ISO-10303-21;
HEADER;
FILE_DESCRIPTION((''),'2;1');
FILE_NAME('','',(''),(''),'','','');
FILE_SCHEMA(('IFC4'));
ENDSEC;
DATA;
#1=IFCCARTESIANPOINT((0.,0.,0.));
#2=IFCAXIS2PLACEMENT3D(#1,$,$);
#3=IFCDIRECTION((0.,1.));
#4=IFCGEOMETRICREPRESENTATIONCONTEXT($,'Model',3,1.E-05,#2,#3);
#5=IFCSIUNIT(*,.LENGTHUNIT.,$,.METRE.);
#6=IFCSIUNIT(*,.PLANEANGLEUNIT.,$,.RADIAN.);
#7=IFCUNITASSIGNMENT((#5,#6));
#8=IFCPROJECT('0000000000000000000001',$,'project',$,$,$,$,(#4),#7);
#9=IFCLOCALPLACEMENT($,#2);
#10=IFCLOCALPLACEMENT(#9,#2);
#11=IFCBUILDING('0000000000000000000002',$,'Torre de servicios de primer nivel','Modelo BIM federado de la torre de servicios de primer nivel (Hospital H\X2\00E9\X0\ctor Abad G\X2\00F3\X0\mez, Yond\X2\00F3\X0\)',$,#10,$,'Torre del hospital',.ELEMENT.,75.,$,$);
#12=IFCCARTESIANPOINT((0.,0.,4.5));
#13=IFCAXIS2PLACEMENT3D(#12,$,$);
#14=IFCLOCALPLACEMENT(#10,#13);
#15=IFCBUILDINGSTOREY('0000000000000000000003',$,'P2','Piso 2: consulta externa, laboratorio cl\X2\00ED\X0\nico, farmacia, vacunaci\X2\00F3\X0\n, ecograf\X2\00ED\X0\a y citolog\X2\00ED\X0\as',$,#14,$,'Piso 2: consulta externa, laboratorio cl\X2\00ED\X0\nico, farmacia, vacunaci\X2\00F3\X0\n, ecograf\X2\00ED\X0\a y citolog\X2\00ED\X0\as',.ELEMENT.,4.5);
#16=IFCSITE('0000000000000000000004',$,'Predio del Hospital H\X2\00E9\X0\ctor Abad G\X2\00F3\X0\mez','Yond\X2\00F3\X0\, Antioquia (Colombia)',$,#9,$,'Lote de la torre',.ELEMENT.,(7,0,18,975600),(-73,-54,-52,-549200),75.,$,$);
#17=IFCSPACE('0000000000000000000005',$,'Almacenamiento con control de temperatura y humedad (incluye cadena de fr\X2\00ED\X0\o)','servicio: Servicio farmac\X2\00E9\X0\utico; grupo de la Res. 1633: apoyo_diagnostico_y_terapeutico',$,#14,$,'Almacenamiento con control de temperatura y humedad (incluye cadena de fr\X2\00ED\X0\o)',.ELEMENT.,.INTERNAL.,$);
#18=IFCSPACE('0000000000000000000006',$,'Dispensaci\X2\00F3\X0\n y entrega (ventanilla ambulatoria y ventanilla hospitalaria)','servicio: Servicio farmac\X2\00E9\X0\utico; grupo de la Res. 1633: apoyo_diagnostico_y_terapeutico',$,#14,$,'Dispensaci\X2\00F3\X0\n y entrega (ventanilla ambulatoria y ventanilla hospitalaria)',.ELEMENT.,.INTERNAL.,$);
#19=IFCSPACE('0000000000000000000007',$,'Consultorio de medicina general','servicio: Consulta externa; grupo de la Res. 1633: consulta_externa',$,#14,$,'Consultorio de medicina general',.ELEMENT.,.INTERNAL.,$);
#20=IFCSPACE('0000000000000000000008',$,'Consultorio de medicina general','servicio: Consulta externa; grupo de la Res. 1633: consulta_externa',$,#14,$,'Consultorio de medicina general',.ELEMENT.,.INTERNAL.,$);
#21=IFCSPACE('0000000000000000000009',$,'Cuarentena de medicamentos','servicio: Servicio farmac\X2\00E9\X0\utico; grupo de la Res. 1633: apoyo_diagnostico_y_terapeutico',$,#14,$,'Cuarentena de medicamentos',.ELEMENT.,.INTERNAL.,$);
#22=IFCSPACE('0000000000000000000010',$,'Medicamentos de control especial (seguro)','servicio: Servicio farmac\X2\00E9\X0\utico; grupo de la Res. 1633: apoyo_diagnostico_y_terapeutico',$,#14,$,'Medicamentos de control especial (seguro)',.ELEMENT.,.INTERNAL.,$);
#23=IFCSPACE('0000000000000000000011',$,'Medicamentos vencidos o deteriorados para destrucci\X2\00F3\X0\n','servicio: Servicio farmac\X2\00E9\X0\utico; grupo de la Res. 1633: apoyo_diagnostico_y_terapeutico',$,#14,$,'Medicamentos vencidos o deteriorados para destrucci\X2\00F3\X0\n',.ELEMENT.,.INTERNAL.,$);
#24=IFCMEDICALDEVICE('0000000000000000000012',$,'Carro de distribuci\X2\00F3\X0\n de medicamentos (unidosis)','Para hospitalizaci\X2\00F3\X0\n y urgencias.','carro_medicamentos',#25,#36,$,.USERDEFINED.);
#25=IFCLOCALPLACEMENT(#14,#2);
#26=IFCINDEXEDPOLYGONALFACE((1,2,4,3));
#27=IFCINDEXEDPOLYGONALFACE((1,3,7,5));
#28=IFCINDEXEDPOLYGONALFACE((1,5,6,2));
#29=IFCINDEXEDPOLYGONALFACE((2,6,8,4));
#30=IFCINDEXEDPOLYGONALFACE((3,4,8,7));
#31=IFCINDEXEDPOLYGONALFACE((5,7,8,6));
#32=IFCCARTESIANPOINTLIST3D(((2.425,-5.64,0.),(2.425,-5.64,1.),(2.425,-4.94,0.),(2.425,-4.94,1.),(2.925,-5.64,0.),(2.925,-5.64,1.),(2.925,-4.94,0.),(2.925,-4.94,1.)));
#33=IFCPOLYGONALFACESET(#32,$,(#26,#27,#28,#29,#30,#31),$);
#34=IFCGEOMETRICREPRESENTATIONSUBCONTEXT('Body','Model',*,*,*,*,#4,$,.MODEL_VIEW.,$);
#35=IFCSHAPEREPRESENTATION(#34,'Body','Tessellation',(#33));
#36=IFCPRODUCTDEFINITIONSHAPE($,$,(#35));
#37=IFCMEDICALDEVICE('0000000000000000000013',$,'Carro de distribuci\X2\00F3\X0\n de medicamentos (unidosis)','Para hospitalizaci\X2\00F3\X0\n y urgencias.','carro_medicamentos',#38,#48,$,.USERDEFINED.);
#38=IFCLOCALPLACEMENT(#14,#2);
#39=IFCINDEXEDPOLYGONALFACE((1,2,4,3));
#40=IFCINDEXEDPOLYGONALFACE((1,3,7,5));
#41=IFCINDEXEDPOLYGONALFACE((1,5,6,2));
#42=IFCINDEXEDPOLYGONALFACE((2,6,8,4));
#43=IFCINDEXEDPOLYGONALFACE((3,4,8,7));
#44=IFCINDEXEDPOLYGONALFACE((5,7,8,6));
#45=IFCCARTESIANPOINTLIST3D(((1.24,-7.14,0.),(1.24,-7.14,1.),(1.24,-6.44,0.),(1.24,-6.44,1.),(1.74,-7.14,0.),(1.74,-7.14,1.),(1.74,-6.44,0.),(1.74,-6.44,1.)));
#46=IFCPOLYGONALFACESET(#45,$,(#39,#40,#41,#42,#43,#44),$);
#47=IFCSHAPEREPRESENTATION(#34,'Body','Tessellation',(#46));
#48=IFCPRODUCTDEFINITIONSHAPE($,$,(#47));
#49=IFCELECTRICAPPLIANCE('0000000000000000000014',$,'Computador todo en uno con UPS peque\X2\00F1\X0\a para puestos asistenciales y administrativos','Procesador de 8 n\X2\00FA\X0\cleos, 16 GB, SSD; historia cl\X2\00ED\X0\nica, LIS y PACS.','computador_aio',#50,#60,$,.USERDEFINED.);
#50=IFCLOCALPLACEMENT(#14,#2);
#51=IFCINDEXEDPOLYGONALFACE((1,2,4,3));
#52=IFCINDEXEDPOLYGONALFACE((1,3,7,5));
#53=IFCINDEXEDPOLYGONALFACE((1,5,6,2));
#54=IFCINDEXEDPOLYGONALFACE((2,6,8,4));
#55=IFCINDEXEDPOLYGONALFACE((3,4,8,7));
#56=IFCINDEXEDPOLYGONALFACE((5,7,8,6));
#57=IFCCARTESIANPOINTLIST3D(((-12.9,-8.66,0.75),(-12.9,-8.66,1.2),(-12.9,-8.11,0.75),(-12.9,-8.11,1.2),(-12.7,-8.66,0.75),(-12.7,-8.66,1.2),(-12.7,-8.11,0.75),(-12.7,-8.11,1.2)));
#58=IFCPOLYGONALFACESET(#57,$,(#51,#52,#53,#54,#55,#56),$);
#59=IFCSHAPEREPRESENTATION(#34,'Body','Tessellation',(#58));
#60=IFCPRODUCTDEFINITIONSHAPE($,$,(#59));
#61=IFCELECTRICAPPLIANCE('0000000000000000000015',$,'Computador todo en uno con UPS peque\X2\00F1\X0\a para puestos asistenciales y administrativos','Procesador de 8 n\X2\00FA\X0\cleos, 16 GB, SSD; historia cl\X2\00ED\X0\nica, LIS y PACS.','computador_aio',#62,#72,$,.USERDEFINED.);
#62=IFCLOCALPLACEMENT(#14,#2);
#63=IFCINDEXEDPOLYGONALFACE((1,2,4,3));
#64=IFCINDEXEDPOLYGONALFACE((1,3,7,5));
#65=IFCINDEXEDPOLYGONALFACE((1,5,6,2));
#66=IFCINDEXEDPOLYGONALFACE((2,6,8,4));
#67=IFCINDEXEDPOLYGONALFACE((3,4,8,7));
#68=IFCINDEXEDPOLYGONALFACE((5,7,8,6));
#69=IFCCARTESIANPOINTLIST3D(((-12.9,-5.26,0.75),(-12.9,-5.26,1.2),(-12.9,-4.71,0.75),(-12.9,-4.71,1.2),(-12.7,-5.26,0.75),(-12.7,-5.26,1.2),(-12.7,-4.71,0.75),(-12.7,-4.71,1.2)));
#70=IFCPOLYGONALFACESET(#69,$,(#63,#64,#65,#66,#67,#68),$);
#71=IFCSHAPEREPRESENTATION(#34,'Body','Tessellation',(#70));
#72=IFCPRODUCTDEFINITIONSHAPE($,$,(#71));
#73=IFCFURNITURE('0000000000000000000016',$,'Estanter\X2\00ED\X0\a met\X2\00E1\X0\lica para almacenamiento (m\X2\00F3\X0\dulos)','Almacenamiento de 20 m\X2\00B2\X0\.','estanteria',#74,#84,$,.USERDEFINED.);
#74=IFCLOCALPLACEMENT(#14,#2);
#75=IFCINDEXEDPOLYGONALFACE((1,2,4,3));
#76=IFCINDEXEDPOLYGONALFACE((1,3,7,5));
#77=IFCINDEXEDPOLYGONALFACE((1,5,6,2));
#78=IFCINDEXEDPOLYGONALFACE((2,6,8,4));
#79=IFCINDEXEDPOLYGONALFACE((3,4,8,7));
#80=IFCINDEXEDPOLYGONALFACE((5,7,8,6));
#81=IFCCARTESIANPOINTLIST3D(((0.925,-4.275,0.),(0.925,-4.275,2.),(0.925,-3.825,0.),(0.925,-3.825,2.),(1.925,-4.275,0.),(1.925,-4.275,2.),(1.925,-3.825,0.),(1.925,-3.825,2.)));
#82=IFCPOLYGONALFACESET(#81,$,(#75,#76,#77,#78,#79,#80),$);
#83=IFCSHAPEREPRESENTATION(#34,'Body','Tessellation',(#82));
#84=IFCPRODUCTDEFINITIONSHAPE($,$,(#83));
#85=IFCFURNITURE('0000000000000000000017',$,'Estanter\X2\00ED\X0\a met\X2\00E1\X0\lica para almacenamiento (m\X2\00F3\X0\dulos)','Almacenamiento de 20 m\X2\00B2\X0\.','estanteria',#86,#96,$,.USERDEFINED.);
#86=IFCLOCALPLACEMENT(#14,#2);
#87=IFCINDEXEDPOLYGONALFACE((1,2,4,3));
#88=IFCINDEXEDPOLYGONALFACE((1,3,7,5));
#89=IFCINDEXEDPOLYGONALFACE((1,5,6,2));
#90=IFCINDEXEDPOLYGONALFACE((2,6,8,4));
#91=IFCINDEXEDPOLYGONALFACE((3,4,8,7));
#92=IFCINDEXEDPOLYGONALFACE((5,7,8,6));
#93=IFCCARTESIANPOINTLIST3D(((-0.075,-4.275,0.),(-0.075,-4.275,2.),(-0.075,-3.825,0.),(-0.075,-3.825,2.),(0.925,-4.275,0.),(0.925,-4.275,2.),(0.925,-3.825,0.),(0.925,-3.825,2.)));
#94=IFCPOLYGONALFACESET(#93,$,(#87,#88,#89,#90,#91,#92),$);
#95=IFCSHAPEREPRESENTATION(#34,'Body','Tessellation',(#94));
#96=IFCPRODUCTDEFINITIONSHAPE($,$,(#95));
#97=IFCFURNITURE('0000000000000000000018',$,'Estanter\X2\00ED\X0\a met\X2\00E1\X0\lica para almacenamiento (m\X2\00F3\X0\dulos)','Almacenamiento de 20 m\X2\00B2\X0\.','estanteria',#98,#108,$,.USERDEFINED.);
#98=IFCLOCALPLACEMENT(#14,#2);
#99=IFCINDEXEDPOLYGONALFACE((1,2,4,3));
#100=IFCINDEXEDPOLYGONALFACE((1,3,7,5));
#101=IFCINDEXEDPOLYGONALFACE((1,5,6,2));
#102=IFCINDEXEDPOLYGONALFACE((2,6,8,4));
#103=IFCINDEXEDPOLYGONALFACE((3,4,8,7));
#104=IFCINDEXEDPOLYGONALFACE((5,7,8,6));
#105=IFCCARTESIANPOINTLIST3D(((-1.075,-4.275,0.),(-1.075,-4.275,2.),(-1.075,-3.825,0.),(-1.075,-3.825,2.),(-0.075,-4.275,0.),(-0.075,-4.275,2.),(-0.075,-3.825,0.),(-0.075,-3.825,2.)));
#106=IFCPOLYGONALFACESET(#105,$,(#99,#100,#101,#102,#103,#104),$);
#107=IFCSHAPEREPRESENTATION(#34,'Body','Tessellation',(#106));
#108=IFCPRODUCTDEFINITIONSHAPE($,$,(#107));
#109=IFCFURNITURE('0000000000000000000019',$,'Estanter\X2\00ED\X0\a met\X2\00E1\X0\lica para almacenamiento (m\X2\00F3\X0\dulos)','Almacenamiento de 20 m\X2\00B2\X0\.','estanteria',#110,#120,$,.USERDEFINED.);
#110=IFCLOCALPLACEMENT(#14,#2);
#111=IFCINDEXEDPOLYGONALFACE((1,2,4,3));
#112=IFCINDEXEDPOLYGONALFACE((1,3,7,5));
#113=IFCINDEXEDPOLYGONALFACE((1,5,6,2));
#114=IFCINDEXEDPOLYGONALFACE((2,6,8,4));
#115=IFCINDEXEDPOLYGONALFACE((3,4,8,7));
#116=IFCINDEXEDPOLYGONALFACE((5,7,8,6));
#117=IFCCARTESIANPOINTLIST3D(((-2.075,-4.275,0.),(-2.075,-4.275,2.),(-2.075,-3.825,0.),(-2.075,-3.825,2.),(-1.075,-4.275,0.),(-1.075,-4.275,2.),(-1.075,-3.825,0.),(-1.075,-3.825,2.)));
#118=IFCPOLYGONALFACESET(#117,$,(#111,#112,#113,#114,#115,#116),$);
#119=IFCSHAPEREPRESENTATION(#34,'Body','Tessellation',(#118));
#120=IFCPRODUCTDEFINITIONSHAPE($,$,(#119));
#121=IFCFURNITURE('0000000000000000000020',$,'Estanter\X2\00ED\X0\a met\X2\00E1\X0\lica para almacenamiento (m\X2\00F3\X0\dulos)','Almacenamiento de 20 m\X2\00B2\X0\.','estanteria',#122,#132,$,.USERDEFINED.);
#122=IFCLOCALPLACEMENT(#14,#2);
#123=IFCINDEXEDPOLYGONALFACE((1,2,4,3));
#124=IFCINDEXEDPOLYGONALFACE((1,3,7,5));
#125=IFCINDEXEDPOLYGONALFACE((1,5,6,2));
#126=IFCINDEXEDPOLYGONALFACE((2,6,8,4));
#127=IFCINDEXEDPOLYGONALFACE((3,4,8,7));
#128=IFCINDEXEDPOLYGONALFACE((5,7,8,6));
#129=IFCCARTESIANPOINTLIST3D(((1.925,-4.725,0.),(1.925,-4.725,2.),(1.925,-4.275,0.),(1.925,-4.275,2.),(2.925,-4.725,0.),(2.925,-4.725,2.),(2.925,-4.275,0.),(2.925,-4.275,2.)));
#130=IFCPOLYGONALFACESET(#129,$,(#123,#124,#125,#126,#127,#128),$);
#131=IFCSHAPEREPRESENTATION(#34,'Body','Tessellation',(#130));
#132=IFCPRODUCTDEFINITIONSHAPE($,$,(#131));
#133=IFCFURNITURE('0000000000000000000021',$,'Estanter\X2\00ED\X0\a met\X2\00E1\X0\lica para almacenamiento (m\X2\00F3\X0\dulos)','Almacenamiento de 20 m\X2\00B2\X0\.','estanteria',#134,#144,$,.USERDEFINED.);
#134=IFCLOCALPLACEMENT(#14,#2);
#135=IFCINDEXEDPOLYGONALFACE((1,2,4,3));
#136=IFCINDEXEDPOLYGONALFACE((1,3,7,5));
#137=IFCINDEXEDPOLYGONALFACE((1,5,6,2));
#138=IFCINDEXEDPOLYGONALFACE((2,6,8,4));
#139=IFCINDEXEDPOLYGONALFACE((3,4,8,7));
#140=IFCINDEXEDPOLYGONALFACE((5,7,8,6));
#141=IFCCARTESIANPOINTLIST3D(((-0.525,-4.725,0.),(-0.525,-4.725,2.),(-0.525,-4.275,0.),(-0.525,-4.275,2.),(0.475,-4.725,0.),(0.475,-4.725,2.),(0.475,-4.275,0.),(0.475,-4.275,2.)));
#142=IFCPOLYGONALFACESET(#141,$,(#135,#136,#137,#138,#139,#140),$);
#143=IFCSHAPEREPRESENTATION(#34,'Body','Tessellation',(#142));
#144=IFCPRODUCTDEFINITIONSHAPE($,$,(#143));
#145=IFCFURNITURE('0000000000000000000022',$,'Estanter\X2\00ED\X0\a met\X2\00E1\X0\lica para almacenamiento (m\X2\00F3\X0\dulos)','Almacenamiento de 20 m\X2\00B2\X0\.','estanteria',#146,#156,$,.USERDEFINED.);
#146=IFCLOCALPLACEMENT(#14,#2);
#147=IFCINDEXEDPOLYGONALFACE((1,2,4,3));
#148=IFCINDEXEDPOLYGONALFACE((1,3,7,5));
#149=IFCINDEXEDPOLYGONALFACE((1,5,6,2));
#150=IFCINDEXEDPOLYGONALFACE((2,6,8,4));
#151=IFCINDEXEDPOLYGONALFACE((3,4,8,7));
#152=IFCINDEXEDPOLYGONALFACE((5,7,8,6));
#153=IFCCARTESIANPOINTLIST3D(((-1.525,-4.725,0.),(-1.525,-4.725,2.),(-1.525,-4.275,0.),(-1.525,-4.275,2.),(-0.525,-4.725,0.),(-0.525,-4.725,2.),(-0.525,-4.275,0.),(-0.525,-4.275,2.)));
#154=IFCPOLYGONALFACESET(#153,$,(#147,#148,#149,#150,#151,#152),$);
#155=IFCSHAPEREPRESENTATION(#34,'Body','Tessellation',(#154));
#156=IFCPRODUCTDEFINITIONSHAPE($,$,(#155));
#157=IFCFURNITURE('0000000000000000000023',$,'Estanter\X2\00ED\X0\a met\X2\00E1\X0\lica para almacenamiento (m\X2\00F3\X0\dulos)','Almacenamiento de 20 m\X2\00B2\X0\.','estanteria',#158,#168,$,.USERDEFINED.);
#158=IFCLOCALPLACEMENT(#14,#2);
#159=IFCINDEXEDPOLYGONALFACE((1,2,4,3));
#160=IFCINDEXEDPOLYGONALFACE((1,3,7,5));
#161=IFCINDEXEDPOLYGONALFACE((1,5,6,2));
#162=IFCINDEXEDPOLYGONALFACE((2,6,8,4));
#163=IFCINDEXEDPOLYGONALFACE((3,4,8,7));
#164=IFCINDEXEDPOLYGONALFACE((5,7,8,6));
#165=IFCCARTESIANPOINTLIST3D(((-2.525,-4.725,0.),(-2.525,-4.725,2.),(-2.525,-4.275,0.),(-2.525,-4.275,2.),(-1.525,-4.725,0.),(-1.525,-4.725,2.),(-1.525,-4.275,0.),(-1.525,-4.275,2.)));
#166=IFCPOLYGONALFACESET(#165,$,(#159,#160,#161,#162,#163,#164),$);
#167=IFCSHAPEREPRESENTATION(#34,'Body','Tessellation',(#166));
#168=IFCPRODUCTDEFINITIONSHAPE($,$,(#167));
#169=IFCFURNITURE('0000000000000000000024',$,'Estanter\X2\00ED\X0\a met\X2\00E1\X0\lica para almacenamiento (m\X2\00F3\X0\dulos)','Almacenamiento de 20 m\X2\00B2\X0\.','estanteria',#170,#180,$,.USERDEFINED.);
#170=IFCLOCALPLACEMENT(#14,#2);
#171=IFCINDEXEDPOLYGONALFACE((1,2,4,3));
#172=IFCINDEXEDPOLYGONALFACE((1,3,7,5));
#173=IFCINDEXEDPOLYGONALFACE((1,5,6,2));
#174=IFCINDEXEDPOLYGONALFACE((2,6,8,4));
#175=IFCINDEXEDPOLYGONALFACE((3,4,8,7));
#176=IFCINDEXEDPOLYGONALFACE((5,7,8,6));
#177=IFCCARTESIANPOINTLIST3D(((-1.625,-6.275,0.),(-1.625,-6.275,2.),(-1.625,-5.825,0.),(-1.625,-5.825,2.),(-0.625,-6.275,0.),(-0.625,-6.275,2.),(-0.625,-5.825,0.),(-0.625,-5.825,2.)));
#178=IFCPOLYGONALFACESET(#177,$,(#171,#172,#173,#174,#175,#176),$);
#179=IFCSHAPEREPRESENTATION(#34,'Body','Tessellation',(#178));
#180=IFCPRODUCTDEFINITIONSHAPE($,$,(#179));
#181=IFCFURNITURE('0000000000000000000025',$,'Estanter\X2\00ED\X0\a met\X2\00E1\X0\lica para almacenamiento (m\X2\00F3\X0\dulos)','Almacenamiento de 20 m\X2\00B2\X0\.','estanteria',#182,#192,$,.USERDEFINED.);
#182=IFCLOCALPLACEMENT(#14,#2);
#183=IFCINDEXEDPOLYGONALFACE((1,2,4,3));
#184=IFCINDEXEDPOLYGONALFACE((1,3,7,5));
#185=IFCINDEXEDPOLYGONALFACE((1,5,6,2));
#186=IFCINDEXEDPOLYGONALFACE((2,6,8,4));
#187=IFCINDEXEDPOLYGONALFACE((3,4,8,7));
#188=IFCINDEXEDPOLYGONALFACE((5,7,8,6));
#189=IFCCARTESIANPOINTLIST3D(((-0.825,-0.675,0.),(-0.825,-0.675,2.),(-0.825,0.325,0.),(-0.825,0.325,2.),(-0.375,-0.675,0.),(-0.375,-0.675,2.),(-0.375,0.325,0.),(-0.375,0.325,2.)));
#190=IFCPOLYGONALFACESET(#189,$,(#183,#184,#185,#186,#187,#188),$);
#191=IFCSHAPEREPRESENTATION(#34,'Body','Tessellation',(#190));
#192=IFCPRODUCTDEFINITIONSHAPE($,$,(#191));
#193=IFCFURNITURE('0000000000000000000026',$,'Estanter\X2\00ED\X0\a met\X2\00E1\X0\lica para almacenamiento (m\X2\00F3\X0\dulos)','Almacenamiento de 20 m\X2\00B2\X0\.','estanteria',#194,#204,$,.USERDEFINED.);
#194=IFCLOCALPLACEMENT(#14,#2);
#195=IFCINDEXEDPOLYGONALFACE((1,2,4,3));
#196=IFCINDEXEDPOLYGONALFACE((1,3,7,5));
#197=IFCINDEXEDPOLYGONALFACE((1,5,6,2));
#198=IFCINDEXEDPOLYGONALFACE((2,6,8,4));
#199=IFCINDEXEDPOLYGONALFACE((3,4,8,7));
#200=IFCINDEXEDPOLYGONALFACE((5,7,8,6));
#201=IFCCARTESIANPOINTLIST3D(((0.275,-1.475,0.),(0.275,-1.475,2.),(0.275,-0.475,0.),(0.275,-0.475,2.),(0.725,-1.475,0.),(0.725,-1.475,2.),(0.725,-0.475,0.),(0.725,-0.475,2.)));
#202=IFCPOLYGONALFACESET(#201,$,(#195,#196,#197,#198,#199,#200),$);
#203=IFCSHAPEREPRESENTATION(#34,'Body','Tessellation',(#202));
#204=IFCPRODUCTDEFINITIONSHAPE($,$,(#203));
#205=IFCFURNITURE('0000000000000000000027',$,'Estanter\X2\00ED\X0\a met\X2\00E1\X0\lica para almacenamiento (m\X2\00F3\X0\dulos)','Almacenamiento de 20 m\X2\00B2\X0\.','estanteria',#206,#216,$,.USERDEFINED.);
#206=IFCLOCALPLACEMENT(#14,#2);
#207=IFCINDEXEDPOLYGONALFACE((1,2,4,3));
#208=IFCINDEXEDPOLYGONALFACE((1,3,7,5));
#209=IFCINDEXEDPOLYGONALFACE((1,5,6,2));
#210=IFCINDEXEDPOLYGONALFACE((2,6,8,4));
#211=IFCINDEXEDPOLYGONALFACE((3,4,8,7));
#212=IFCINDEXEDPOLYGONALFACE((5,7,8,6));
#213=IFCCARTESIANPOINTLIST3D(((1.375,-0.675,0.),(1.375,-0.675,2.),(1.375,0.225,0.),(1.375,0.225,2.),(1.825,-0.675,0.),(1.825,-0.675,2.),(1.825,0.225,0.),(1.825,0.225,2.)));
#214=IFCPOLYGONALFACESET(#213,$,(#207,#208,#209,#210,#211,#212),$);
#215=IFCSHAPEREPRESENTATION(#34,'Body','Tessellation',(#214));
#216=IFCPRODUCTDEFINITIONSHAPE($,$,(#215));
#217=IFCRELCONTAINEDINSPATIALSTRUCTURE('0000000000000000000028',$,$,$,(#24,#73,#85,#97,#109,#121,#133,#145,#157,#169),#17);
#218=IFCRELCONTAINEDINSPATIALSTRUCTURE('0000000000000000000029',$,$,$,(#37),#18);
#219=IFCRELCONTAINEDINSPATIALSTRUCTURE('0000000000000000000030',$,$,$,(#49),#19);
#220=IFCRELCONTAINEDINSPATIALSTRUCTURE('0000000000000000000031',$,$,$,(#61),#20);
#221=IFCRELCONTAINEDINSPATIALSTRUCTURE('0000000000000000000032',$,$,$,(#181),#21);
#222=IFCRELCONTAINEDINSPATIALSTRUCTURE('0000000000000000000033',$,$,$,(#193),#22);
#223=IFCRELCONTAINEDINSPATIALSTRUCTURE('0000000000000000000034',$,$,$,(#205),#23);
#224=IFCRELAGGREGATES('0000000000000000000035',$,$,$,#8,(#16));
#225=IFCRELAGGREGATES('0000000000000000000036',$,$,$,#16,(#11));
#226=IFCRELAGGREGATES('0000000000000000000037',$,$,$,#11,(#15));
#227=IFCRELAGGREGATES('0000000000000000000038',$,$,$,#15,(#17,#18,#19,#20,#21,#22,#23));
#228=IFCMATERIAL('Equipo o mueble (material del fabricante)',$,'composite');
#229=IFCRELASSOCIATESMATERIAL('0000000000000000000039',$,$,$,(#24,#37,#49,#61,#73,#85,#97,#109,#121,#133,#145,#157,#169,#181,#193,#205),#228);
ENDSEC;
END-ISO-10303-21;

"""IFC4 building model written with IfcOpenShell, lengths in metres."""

from ifc_helpers import new_model, si_unit, direction, frame, origin, place, context, subcontext, project, spatial, rectangle, extrude, material, element, save


model = new_model("IFC4")

# Units and contexts
model_context = context("Model", 3, precision=1e-05, world=origin(), true_north=direction((0.0, 1.0)))
body_context = subcontext(model_context, "Body", "Model", "MODEL_VIEW")
ifc_project = project(units=[si_unit("LENGTHUNIT", "METRE"), si_unit("PLANEANGLEUNIT", "RADIAN")], contexts=[model_context])

# Site, building, storey, space
site_placement = place(None, origin())
site = spatial("IfcSite", under=ifc_project, at=site_placement, Name="Predio del Hospital Héctor Abad Gómez", Description="Yondó, Antioquia (Colombia)", LongName="Lote de la torre", CompositionType="ELEMENT", RefLatitude=(7, 0, 18, 975600), RefLongitude=(-73, -54, -52, -549200), RefElevation=75.0)
building_placement = place(site_placement, origin())
building = spatial("IfcBuilding", under=site, at=building_placement, Name="Torre de servicios de primer nivel", Description="Modelo BIM federado de la torre de servicios de primer nivel (Hospital Héctor Abad Gómez, Yondó)", LongName="Torre del hospital", CompositionType="ELEMENT", ElevationOfRefHeight=75.0)
placement = place(building_placement, frame((0.0, 0.0, 4.5)))
storey = spatial("IfcBuildingStorey", under=building, at=placement, Name="P2", Description="Piso 2: consulta externa, laboratorio clínico, farmacia, vacunación, ecografía y citologías", LongName="Piso 2: consulta externa, laboratorio clínico, farmacia, vacunación, ecografía y citologías", CompositionType="ELEMENT", Elevation=4.5)
space_1 = spatial("IfcSpace", under=storey, at=placement, Name="Almacenamiento con control de temperatura y humedad (incluye cadena de frío)", Description="servicio: Servicio farmacéutico; grupo de la Res. 1633: apoyo_diagnostico_y_terapeutico", LongName="Almacenamiento con control de temperatura y humedad (incluye cadena de frío)", CompositionType="ELEMENT", PredefinedType="INTERNAL")

# Medical device
ifc_material = material(Name="Equipo o mueble (material del fabricante)", Category="composite")
element("IfcMedicalDevice", 1, at=placement, inside=space_1, material=ifc_material, Name="Carro de distribución de medicamentos (unidosis)", Description="Para hospitalización y urgencias.", ObjectType="carro_medicamentos", PredefinedType="USERDEFINED", context=body_context, shape_type="SweptSolid", body=[
    extrude(rectangle(XDim=0.7, YDim=0.5), frame((2.675, -5.29, 0.0), z_axis=(0.0, 0.0, 1.0), x_axis=(0.0, 1.0, 0.0)), (0.0, 0.0, 1.0), 1.0),
])

# Shared definitions
space_2 = spatial("IfcSpace", under=storey, at=placement, Name="Dispensación y entrega (ventanilla ambulatoria y ventanilla hospitalaria)", Description="servicio: Servicio farmacéutico; grupo de la Res. 1633: apoyo_diagnostico_y_terapeutico", LongName="Dispensación y entrega (ventanilla ambulatoria y ventanilla hospitalaria)", CompositionType="ELEMENT", PredefinedType="INTERNAL")

# Medical device
element("IfcMedicalDevice", 2, at=placement, inside=space_2, material=ifc_material, Name="Carro de distribución de medicamentos (unidosis)", Description="Para hospitalización y urgencias.", ObjectType="carro_medicamentos", PredefinedType="USERDEFINED", context=body_context, shape_type="SweptSolid", body=[
    extrude(rectangle(XDim=0.7, YDim=0.5), frame((1.49, -6.79, 0.0), z_axis=(0.0, 0.0, 1.0), x_axis=(0.0, 1.0, 0.0)), (0.0, 0.0, 1.0), 1.0),
])

# Shared definitions
space_3 = spatial("IfcSpace", under=storey, at=placement, Name="Consultorio de medicina general", Description="servicio: Consulta externa; grupo de la Res. 1633: consulta_externa", LongName="Consultorio de medicina general", CompositionType="ELEMENT", PredefinedType="INTERNAL")

# Electric appliance
element("IfcElectricAppliance", 3, at=placement, inside=space_3, material=ifc_material, Name="Computador todo en uno con UPS pequeña para puestos asistenciales y administrativos", Description="Procesador de 8 núcleos, 16 GB, SSD; historia clínica, LIS y PACS.", ObjectType="computador_aio", PredefinedType="USERDEFINED", context=body_context, shape_type="SweptSolid", body=[
    extrude(rectangle(XDim=0.55, YDim=0.2), frame((-12.8, -8.385, 0.75), z_axis=(0.0, 0.0, 1.0), x_axis=(0.0, -1.0, 0.0)), (0.0, 0.0, 1.0), 0.45),
])

# Shared definitions
space_4 = spatial("IfcSpace", under=storey, at=placement, Name="Consultorio de medicina general", Description="servicio: Consulta externa; grupo de la Res. 1633: consulta_externa", LongName="Consultorio de medicina general", CompositionType="ELEMENT", PredefinedType="INTERNAL")

# Electric appliance
element("IfcElectricAppliance", 4, at=placement, inside=space_4, material=ifc_material, Name="Computador todo en uno con UPS pequeña para puestos asistenciales y administrativos", Description="Procesador de 8 núcleos, 16 GB, SSD; historia clínica, LIS y PACS.", ObjectType="computador_aio", PredefinedType="USERDEFINED", context=body_context, shape_type="SweptSolid", body=[
    extrude(rectangle(XDim=0.55, YDim=0.2), frame((-12.8, -4.985, 0.75), z_axis=(0.0, 0.0, 1.0), x_axis=(0.0, -1.0, 0.0)), (0.0, 0.0, 1.0), 0.45),
])

# Furniture
element("IfcFurniture", 5, at=placement, inside=space_1, material=ifc_material, Name="Estantería metálica para almacenamiento (módulos)", Description="Almacenamiento de 20 m².", ObjectType="estanteria", PredefinedType="USERDEFINED", context=body_context, shape_type="SweptSolid", body=[
    extrude(rectangle(XDim=1.0, YDim=0.45), frame((1.425, -4.05, 0.0)), (0.0, 0.0, 1.0), 2.0),
])
element("IfcFurniture", 6, at=placement, inside=space_1, material=ifc_material, Name="Estantería metálica para almacenamiento (módulos)", Description="Almacenamiento de 20 m².", ObjectType="estanteria", PredefinedType="USERDEFINED", context=body_context, shape_type="SweptSolid", body=[
    extrude(rectangle(XDim=1.0, YDim=0.45), frame((0.425, -4.05, 0.0)), (0.0, 0.0, 1.0), 2.0),
])
element("IfcFurniture", 7, at=placement, inside=space_1, material=ifc_material, Name="Estantería metálica para almacenamiento (módulos)", Description="Almacenamiento de 20 m².", ObjectType="estanteria", PredefinedType="USERDEFINED", context=body_context, shape_type="SweptSolid", body=[
    extrude(rectangle(XDim=1.0, YDim=0.45), frame((-0.575, -4.05, 0.0)), (0.0, 0.0, 1.0), 2.0),
])
element("IfcFurniture", 8, at=placement, inside=space_1, material=ifc_material, Name="Estantería metálica para almacenamiento (módulos)", Description="Almacenamiento de 20 m².", ObjectType="estanteria", PredefinedType="USERDEFINED", context=body_context, shape_type="SweptSolid", body=[
    extrude(rectangle(XDim=1.0, YDim=0.45), frame((-1.575, -4.05, 0.0)), (0.0, 0.0, 1.0), 2.0),
])
element("IfcFurniture", 9, at=placement, inside=space_1, material=ifc_material, Name="Estantería metálica para almacenamiento (módulos)", Description="Almacenamiento de 20 m².", ObjectType="estanteria", PredefinedType="USERDEFINED", context=body_context, shape_type="SweptSolid", body=[
    extrude(rectangle(XDim=1.0, YDim=0.45), frame((2.425, -4.5, 0.0), z_axis=(0.0, 0.0, 1.0), x_axis=(-1.0, 0.0, 0.0)), (0.0, 0.0, 1.0), 2.0),
])
element("IfcFurniture", 10, at=placement, inside=space_1, material=ifc_material, Name="Estantería metálica para almacenamiento (módulos)", Description="Almacenamiento de 20 m².", ObjectType="estanteria", PredefinedType="USERDEFINED", context=body_context, shape_type="SweptSolid", body=[
    extrude(rectangle(XDim=1.0, YDim=0.45), frame((-0.025, -4.5, 0.0), z_axis=(0.0, 0.0, 1.0), x_axis=(-1.0, 0.0, 0.0)), (0.0, 0.0, 1.0), 2.0),
])
element("IfcFurniture", 11, at=placement, inside=space_1, material=ifc_material, Name="Estantería metálica para almacenamiento (módulos)", Description="Almacenamiento de 20 m².", ObjectType="estanteria", PredefinedType="USERDEFINED", context=body_context, shape_type="SweptSolid", body=[
    extrude(rectangle(XDim=1.0, YDim=0.45), frame((-1.025, -4.5, 0.0), z_axis=(0.0, 0.0, 1.0), x_axis=(-1.0, 0.0, 0.0)), (0.0, 0.0, 1.0), 2.0),
])
element("IfcFurniture", 12, at=placement, inside=space_1, material=ifc_material, Name="Estantería metálica para almacenamiento (módulos)", Description="Almacenamiento de 20 m².", ObjectType="estanteria", PredefinedType="USERDEFINED", context=body_context, shape_type="SweptSolid", body=[
    extrude(rectangle(XDim=1.0, YDim=0.45), frame((-2.025, -4.5, 0.0), z_axis=(0.0, 0.0, 1.0), x_axis=(-1.0, 0.0, 0.0)), (0.0, 0.0, 1.0), 2.0),
])
element("IfcFurniture", 13, at=placement, inside=space_1, material=ifc_material, Name="Estantería metálica para almacenamiento (módulos)", Description="Almacenamiento de 20 m².", ObjectType="estanteria", PredefinedType="USERDEFINED", context=body_context, shape_type="SweptSolid", body=[
    extrude(rectangle(XDim=1.0, YDim=0.45), frame((-1.125, -6.05, 0.0)), (0.0, 0.0, 1.0), 2.0),
])

# Shared definitions
space_5 = spatial("IfcSpace", under=storey, at=placement, Name="Cuarentena de medicamentos", Description="servicio: Servicio farmacéutico; grupo de la Res. 1633: apoyo_diagnostico_y_terapeutico", LongName="Cuarentena de medicamentos", CompositionType="ELEMENT", PredefinedType="INTERNAL")

# Furniture
element("IfcFurniture", 14, at=placement, inside=space_5, material=ifc_material, Name="Estantería metálica para almacenamiento (módulos)", Description="Almacenamiento de 20 m².", ObjectType="estanteria", PredefinedType="USERDEFINED", context=body_context, shape_type="SweptSolid", body=[
    extrude(rectangle(XDim=1.0, YDim=0.45), frame((-0.6, -0.175, 0.0), z_axis=(0.0, 0.0, 1.0), x_axis=(0.0, 1.0, 0.0)), (0.0, 0.0, 1.0), 2.0),
])

# Shared definitions
space_6 = spatial("IfcSpace", under=storey, at=placement, Name="Medicamentos de control especial (seguro)", Description="servicio: Servicio farmacéutico; grupo de la Res. 1633: apoyo_diagnostico_y_terapeutico", LongName="Medicamentos de control especial (seguro)", CompositionType="ELEMENT", PredefinedType="INTERNAL")

# Furniture
element("IfcFurniture", 15, at=placement, inside=space_6, material=ifc_material, Name="Estantería metálica para almacenamiento (módulos)", Description="Almacenamiento de 20 m².", ObjectType="estanteria", PredefinedType="USERDEFINED", context=body_context, shape_type="SweptSolid", body=[
    extrude(rectangle(XDim=1.0, YDim=0.45), frame((0.5, -0.975, 0.0), z_axis=(0.0, 0.0, 1.0), x_axis=(0.0, 1.0, 0.0)), (0.0, 0.0, 1.0), 2.0),
])

# Shared definitions
space_7 = spatial("IfcSpace", under=storey, at=placement, Name="Medicamentos vencidos o deteriorados para destrucción", Description="servicio: Servicio farmacéutico; grupo de la Res. 1633: apoyo_diagnostico_y_terapeutico", LongName="Medicamentos vencidos o deteriorados para destrucción", CompositionType="ELEMENT", PredefinedType="INTERNAL")

# Furniture
element("IfcFurniture", 16, at=placement, inside=space_7, material=ifc_material, Name="Estantería metálica para almacenamiento (módulos)", Description="Almacenamiento de 20 m².", ObjectType="estanteria", PredefinedType="USERDEFINED", context=body_context, shape_type="SweptSolid", body=[
    extrude(rectangle(XDim=0.9, YDim=0.45), frame((1.6, -0.225, 0.0), z_axis=(0.0, 0.0, 1.0), x_axis=(0.0, 1.0, 0.0)), (0.0, 0.0, 1.0), 2.0),
])

save(model, "model.ifc")
